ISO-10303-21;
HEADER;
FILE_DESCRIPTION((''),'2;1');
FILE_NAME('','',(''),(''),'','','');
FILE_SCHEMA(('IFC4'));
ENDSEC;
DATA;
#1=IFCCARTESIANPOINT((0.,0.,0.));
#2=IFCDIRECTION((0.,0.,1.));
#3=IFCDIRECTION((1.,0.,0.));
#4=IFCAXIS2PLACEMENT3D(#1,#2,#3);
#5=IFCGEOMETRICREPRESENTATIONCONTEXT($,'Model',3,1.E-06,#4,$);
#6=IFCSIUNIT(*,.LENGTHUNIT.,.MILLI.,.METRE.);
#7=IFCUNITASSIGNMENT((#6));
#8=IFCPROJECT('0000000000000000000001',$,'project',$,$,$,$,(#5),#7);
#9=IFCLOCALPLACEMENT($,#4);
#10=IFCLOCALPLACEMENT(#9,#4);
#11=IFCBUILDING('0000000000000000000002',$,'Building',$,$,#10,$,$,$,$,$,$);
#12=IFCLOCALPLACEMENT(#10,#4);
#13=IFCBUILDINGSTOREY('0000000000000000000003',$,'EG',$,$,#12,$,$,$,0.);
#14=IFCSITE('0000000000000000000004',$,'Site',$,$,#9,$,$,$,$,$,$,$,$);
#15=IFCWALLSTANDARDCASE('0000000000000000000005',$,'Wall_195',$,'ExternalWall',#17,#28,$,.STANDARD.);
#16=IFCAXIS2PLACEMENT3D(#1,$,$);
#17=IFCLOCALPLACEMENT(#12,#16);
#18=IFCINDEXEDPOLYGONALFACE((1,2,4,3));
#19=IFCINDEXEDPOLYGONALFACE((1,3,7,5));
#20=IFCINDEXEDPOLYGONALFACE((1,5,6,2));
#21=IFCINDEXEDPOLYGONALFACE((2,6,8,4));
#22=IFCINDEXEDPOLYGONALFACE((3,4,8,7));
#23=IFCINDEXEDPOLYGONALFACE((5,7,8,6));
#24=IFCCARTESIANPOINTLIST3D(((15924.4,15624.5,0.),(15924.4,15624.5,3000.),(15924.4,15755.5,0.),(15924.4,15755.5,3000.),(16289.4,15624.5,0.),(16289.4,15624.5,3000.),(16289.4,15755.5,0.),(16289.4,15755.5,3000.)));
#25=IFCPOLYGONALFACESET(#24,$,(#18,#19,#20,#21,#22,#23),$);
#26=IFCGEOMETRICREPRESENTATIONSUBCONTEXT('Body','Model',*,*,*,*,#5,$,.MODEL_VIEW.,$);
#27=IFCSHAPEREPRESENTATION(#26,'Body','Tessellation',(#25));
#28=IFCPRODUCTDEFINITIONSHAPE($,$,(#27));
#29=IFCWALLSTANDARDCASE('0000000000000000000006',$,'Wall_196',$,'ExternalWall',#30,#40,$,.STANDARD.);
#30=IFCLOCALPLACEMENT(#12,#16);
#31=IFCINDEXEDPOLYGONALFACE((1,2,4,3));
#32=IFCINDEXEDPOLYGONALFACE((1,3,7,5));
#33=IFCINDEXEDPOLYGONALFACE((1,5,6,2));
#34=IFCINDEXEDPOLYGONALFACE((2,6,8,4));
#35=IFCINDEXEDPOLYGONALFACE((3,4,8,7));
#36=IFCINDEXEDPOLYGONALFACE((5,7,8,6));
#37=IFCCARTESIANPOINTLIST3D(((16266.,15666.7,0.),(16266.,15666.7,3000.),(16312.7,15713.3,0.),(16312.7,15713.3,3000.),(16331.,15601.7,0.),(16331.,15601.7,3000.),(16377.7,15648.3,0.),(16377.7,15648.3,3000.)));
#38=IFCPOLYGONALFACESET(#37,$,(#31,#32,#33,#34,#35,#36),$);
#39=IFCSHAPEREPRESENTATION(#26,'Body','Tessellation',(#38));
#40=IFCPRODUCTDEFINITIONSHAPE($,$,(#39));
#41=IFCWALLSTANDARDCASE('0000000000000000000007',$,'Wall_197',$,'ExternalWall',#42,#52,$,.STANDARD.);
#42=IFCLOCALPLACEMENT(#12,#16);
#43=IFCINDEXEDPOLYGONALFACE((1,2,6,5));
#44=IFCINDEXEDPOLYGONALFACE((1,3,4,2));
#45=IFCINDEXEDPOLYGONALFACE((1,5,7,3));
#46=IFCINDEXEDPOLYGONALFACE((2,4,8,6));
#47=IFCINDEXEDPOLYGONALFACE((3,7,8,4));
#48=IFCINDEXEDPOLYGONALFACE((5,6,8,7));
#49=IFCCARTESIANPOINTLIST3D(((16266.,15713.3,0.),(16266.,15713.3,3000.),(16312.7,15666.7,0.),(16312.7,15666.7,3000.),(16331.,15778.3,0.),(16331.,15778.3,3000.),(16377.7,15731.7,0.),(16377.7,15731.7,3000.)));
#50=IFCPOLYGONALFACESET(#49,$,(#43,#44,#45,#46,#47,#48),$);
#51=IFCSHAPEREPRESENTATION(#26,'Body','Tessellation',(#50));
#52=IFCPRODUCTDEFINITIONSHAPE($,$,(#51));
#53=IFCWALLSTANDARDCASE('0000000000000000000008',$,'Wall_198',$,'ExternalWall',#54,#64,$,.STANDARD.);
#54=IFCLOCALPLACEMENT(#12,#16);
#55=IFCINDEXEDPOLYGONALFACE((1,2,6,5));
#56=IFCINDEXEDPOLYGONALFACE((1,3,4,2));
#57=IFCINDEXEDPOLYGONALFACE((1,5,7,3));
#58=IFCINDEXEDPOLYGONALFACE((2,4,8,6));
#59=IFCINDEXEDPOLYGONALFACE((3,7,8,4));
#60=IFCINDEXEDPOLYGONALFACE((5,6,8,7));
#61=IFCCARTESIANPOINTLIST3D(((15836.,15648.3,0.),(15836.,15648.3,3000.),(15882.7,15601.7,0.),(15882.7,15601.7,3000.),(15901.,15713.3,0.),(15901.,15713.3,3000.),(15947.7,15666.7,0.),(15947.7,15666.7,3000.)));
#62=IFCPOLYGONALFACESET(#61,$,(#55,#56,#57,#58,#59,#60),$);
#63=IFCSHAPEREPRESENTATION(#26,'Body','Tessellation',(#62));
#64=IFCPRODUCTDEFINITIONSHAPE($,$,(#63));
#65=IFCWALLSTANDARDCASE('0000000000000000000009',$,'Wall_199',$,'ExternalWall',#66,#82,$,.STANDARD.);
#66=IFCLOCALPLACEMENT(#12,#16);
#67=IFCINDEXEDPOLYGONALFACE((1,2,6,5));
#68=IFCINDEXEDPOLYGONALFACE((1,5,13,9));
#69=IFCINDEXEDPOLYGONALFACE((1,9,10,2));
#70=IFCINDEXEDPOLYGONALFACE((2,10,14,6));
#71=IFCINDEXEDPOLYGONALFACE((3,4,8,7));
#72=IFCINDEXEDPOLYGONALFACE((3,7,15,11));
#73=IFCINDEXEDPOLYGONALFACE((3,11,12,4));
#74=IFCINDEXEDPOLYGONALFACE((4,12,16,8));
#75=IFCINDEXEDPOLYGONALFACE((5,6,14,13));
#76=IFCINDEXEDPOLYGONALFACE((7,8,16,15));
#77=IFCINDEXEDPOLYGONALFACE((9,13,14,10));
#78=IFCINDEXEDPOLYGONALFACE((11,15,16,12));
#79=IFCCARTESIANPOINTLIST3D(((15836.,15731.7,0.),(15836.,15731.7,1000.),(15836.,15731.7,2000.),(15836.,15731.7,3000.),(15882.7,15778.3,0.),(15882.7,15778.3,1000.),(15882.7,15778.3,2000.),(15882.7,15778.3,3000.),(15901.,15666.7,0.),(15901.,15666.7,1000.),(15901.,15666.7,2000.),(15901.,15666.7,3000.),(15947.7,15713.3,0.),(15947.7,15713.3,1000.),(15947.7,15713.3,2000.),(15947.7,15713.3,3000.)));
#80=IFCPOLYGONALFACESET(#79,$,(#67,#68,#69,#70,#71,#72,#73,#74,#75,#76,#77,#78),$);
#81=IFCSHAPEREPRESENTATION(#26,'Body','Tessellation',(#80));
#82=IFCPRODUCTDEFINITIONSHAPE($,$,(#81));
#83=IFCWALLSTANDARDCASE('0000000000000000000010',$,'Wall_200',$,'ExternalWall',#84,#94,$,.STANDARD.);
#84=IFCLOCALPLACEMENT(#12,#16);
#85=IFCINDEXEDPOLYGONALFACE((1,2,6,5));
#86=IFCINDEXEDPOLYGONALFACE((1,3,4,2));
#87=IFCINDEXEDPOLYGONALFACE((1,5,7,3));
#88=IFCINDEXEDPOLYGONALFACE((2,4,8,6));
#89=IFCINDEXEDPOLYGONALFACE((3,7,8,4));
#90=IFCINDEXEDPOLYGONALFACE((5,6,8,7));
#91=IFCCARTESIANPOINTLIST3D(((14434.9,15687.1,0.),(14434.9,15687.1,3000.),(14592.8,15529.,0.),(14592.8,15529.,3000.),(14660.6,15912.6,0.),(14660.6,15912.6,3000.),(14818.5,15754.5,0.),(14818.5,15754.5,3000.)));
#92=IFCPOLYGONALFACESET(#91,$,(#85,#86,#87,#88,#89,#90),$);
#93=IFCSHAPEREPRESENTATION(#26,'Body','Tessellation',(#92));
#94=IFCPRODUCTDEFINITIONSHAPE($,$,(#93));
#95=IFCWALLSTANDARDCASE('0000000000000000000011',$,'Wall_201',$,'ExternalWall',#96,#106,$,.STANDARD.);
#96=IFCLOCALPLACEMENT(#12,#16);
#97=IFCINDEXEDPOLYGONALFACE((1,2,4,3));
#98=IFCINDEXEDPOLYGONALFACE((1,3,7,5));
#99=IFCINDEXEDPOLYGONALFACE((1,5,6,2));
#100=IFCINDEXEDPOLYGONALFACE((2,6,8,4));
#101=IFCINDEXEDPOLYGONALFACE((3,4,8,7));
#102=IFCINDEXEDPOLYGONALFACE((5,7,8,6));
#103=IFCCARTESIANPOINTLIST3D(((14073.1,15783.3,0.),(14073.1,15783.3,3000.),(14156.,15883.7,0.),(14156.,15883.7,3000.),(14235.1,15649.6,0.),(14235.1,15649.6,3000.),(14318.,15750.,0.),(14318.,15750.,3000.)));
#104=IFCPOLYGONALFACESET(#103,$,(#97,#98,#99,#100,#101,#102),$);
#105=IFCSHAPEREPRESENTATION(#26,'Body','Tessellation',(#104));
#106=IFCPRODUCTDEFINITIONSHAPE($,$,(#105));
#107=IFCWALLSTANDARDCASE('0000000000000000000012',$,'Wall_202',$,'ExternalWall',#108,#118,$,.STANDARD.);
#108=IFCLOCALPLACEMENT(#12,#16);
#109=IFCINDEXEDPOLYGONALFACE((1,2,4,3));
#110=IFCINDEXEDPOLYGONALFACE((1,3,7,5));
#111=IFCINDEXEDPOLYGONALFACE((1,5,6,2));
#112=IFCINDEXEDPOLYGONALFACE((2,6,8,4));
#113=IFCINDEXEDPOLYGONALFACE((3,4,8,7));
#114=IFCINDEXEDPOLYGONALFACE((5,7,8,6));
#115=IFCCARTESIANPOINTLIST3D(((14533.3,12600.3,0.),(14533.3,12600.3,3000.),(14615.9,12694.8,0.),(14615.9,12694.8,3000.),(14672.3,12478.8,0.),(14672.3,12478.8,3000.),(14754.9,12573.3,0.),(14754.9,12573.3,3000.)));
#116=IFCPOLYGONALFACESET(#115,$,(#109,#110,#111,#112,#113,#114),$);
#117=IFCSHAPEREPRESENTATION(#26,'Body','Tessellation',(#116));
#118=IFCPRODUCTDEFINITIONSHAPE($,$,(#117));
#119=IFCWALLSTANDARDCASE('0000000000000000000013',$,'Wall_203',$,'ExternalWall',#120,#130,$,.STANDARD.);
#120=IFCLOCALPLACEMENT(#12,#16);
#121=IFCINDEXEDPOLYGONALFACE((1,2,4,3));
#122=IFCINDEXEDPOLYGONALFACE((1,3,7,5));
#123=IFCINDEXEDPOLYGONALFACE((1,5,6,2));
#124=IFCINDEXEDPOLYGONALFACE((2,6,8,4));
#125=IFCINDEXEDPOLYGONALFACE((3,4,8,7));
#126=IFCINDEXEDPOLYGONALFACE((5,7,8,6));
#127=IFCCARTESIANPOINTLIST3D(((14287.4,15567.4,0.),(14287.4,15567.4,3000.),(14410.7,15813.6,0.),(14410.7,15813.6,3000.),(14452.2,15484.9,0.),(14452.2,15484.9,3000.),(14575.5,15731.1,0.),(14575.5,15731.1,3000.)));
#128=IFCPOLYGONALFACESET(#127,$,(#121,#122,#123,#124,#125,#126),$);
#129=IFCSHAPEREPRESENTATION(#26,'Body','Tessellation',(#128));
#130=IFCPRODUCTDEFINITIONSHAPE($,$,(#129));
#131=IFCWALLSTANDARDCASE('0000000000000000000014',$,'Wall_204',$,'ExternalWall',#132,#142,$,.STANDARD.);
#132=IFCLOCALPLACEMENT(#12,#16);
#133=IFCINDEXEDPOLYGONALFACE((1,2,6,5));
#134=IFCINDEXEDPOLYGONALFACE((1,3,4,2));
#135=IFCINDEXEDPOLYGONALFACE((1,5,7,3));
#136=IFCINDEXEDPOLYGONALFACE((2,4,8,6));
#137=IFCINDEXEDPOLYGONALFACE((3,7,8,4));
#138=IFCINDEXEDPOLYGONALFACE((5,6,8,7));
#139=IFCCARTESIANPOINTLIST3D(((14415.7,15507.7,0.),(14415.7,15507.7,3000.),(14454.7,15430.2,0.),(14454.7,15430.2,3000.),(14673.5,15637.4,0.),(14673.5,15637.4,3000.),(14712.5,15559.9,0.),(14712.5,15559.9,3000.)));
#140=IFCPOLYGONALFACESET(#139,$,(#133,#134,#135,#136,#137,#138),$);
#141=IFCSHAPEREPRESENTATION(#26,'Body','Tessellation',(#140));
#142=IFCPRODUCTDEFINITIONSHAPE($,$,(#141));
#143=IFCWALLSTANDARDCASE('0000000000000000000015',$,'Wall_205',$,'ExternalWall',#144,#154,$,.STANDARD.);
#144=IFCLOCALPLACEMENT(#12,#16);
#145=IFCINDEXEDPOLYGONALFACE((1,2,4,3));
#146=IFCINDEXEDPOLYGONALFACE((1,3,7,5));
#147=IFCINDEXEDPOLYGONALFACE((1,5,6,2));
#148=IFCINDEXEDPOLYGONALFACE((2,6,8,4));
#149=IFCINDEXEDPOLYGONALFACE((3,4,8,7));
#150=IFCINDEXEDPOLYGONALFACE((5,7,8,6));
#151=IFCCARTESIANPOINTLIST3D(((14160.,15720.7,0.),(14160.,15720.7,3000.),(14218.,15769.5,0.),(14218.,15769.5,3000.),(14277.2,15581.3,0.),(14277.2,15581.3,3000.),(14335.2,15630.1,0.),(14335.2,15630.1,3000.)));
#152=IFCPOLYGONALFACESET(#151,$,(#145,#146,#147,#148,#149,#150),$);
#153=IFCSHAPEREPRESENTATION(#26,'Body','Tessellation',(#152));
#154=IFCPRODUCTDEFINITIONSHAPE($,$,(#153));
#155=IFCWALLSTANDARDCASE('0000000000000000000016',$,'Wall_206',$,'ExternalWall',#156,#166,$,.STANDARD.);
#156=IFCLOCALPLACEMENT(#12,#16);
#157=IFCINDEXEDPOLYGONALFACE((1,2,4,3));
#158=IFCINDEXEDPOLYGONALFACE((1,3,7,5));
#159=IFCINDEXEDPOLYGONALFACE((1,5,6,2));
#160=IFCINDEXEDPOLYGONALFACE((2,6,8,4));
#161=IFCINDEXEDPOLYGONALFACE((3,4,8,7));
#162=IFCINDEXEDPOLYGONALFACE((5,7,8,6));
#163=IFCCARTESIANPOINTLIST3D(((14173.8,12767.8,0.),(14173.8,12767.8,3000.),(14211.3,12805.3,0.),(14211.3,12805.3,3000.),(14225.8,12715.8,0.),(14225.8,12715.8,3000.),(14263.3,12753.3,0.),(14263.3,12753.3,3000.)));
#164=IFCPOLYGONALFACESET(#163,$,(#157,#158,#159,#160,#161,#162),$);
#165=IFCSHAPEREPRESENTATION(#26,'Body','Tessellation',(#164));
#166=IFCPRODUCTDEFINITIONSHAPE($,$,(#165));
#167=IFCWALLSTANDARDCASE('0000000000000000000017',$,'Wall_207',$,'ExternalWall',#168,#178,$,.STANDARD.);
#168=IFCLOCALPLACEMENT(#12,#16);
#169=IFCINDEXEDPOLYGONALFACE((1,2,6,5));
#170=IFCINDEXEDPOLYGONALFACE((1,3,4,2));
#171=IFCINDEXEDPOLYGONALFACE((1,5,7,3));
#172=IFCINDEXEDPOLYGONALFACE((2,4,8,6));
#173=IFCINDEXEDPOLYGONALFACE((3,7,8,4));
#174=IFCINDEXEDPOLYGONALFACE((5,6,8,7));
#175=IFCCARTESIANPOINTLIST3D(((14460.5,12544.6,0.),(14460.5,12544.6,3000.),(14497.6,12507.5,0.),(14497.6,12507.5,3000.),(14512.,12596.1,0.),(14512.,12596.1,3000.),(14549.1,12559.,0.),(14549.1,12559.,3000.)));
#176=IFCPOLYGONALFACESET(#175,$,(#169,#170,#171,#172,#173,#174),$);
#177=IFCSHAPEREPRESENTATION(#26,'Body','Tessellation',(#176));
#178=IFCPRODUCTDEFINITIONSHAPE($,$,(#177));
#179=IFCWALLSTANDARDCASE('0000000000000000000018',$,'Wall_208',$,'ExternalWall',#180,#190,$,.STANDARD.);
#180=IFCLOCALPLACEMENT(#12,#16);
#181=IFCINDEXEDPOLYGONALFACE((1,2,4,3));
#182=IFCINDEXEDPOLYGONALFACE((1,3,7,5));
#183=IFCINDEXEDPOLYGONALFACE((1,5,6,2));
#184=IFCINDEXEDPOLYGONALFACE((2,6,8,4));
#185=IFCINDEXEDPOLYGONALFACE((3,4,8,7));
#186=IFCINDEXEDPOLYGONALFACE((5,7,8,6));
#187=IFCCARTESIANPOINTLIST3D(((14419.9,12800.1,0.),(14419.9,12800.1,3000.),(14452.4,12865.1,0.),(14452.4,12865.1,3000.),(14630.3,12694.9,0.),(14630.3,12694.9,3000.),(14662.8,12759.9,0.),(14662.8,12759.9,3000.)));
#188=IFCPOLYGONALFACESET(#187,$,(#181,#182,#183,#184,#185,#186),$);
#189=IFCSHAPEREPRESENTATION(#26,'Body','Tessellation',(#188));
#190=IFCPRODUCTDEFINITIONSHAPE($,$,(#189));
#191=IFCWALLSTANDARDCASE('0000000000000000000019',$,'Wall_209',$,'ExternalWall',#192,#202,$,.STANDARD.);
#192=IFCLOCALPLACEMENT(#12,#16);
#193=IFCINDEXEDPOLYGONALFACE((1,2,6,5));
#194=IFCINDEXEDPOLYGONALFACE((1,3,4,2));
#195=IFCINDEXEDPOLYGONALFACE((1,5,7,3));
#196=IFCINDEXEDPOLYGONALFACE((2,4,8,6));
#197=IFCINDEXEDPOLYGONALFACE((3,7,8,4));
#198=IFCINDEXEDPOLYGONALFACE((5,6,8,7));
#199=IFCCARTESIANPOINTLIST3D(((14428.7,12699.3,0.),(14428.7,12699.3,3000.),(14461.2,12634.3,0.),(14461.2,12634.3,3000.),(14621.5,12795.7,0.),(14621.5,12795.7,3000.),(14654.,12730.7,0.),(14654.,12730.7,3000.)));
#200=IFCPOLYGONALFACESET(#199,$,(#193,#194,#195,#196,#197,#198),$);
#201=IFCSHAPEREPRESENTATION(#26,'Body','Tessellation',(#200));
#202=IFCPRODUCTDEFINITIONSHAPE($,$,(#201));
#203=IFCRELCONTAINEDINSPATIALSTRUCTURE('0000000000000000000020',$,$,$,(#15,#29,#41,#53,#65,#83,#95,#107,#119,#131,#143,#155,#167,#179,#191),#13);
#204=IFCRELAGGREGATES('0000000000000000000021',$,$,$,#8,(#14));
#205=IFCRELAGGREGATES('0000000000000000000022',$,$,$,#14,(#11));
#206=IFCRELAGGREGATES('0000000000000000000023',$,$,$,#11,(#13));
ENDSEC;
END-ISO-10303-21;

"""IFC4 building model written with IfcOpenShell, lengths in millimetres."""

from ifc_helpers import new_model, si_unit, frame, origin_with_axes, place, context, subcontext, project, spatial, rectangle, extrude, element, save


model = new_model("IFC4")

# Units and contexts
model_context = context("Model", 3, precision=1e-06, world=origin_with_axes())
body_context = subcontext(model_context, "Body", "Model", "MODEL_VIEW")
ifc_project = project(units=[si_unit("LENGTHUNIT", "METRE", prefix="MILLI")], contexts=[model_context])

# Site, building, storey
site_placement = place(None, origin_with_axes())
site = spatial("IfcSite", under=ifc_project, at=site_placement, Name="Site")
building_placement = place(site_placement, origin_with_axes())
building = spatial("IfcBuilding", under=site, at=building_placement, Name="Building")
storey_placement = place(building_placement, origin_with_axes())
storey = spatial("IfcBuildingStorey", under=building, at=storey_placement, Name="EG", Elevation=0.0)

# Walls
wall_1_placement = place(storey_placement, origin_with_axes())
element("IfcWallStandardCase", 1, at=wall_1_placement, inside=storey, Name="Wall_195", ObjectType="ExternalWall", PredefinedType="STANDARD", context=body_context, shape_type="SweptSolid", body=[
    extrude(rectangle(XDim=365.0, YDim=131.0), frame((16106.9, 15690.0, 0.0), z_axis=(0.0, 0.0, 1.0), x_axis=(-1.0, 0.0, 0.0)), (0.0, 0.0, 1.0), 3000.0),
])
wall_2_placement = place(storey_placement, origin_with_axes())
element("IfcWallStandardCase", 2, at=wall_2_placement, inside=storey, Name="Wall_196", ObjectType="ExternalWall", PredefinedType="STANDARD", context=body_context, shape_type="SweptSolid", body=[
    extrude(rectangle(XDim=91.9, YDim=66.0), frame((16321.9, 15657.5, 0.0), z_axis=(0.0, 0.0, 1.0), x_axis=(0.707107, -0.707107, 0.0)), (0.0, 0.0, 1.0), 3000.0),
])
wall_3_placement = place(storey_placement, origin_with_axes())
element("IfcWallStandardCase", 3, at=wall_3_placement, inside=storey, Name="Wall_197", ObjectType="ExternalWall", PredefinedType="STANDARD", context=body_context, shape_type="SweptSolid", body=[
    extrude(rectangle(XDim=91.9, YDim=66.0), frame((16321.9, 15722.5, 0.0), z_axis=(0.0, 0.0, 1.0), x_axis=(0.707107, 0.707107, 0.0)), (0.0, 0.0, 1.0), 3000.0),
])
wall_4_placement = place(storey_placement, origin_with_axes())
element("IfcWallStandardCase", 4, at=wall_4_placement, inside=storey, Name="Wall_198", ObjectType="ExternalWall", PredefinedType="STANDARD", context=body_context, shape_type="SweptSolid", body=[
    extrude(rectangle(XDim=91.9, YDim=66.0), frame((15891.9, 15657.5, 0.0), z_axis=(0.0, 0.0, 1.0), x_axis=(-0.707107, -0.707107, 0.0)), (0.0, 0.0, 1.0), 3000.0),
])

# Wall, opening
wall_5_placement = place(storey_placement, origin_with_axes())
wall_5 = element("IfcWallStandardCase", 5, at=wall_5_placement, inside=storey, Name="Wall_199", ObjectType="ExternalWall", PredefinedType="STANDARD", context=body_context, shape_type="SweptSolid", body=[
    extrude(rectangle(XDim=91.9, YDim=66.0), frame((15891.9, 15722.5, 0.0), z_axis=(0.0, 0.0, 1.0), x_axis=(-0.707107, 0.707107, 0.0)), (0.0, 0.0, 1.0), 3000.0),
])
opening_placement = place(wall_5_placement, origin_with_axes())
element("IfcOpeningElement", 6, at=opening_placement, inside=storey, cuts=wall_5, context=body_context, shape_type="SweptSolid", body=[
    extrude(rectangle(XDim=600.0, YDim=66.0), frame((15878.9, 15735.5, 1000.0), z_axis=(0.0, 0.0, 1.0), x_axis=(-0.707107, 0.707107, 0.0)), (0.0, 0.0, 1.0), 1000.0),
])

# Walls
wall_6_placement = place(storey_placement, origin_with_axes())
element("IfcWallStandardCase", 7, at=wall_6_placement, inside=storey, Name="Wall_200", ObjectType="ExternalWall", PredefinedType="STANDARD", context=body_context, shape_type="SweptSolid", body=[
    extrude(rectangle(XDim=319.1, YDim=223.5), frame((14626.7, 15720.8, 0.0), z_axis=(0.0, 0.0, 1.0), x_axis=(0.707498, 0.706715, 0.0)), (0.0, 0.0, 1.0), 3000.0),
])
wall_7_placement = place(storey_placement, origin_with_axes())
element("IfcWallStandardCase", 8, at=wall_7_placement, inside=storey, Name="Wall_201", ObjectType="ExternalWall", PredefinedType="STANDARD", context=body_context, shape_type="SweptSolid", body=[
    extrude(rectangle(XDim=210.1, YDim=130.2), frame((14195.6, 15766.7, 0.0), z_axis=(0.0, 0.0, 1.0), x_axis=(-0.77114, 0.636666, 0.0)), (0.0, 0.0, 1.0), 3000.0),
])
wall_8_placement = place(storey_placement, origin_with_axes())
element("IfcWallStandardCase", 9, at=wall_8_placement, inside=storey, Name="Wall_202", ObjectType="ExternalWall", PredefinedType="STANDARD", context=body_context, shape_type="SweptSolid", body=[
    extrude(rectangle(XDim=184.6, YDim=125.5), frame((14644.1, 12586.8, 0.0), z_axis=(0.0, 0.0, 1.0), x_axis=(0.752912, -0.658121, 0.0)), (0.0, 0.0, 1.0), 3000.0),
])
wall_9_placement = place(storey_placement, origin_with_axes())
element("IfcWallStandardCase", 10, at=wall_9_placement, inside=storey, Name="Wall_203", ObjectType="ExternalWall", PredefinedType="STANDARD", context=body_context, shape_type="SweptSolid", body=[
    extrude(rectangle(XDim=184.3, YDim=275.3), frame((14431.5, 15649.3, 0.0), z_axis=(0.0, 0.0, 1.0), x_axis=(-0.894156, 0.447756, 0.0)), (0.0, 0.0, 1.0), 3000.0),
])
wall_10_placement = place(storey_placement, origin_with_axes())
element("IfcWallStandardCase", 11, at=wall_10_placement, inside=storey, Name="Wall_204", ObjectType="ExternalWall", PredefinedType="STANDARD", context=body_context, shape_type="SweptSolid", body=[
    extrude(rectangle(XDim=86.8, YDim=288.6), frame((14564.1, 15533.8, 0.0), z_axis=(0.0, 0.0, 1.0), x_axis=(-0.449517, 0.893272, 0.0)), (0.0, 0.0, 1.0), 3000.0),
])
wall_11_placement = place(storey_placement, origin_with_axes())
element("IfcWallStandardCase", 12, at=wall_11_placement, inside=storey, Name="Wall_205", ObjectType="ExternalWall", PredefinedType="STANDARD", context=body_context, shape_type="SweptSolid", body=[
    extrude(rectangle(XDim=75.8, YDim=182.1), frame((14247.6, 15675.4, 0.0), z_axis=(0.0, 0.0, 1.0), x_axis=(-0.76551, -0.643424, 0.0)), (0.0, 0.0, 1.0), 3000.0),
])
wall_12_placement = place(storey_placement, origin_with_axes())
element("IfcWallStandardCase", 13, at=wall_12_placement, inside=storey, Name="Wall_206", ObjectType="ExternalWall", PredefinedType="STANDARD", context=body_context, shape_type="SweptSolid", body=[
    extrude(rectangle(XDim=73.5, YDim=53.0), frame((14218.6, 12760.5, 0.0), z_axis=(0.0, 0.0, 1.0), x_axis=(0.707107, -0.707107, 0.0)), (0.0, 0.0, 1.0), 3000.0),
])
wall_13_placement = place(storey_placement, origin_with_axes())
element("IfcWallStandardCase", 14, at=wall_13_placement, inside=storey, Name="Wall_207", ObjectType="ExternalWall", PredefinedType="STANDARD", context=body_context, shape_type="SweptSolid", body=[
    extrude(rectangle(XDim=72.8, YDim=52.5), frame((14504.8, 12551.8, 0.0), z_axis=(0.0, 0.0, 1.0), x_axis=(-0.707107, -0.707107, 0.0)), (0.0, 0.0, 1.0), 3000.0),
])
wall_14_placement = place(storey_placement, origin_with_axes())
element("IfcWallStandardCase", 15, at=wall_14_placement, inside=storey, Name="Wall_208", ObjectType="ExternalWall", PredefinedType="STANDARD", context=body_context, shape_type="SweptSolid", body=[
    extrude(rectangle(XDim=72.7, YDim=235.2), frame((14541.3, 12780.0, 0.0), z_axis=(0.0, 0.0, 1.0), x_axis=(-0.447214, -0.894427, 0.0)), (0.0, 0.0, 1.0), 3000.0),
])
wall_15_placement = place(storey_placement, origin_with_axes())
element("IfcWallStandardCase", 16, at=wall_15_placement, inside=storey, Name="Wall_209", ObjectType="ExternalWall", PredefinedType="STANDARD", context=body_context, shape_type="SweptSolid", body=[
    extrude(rectangle(XDim=72.7, YDim=215.6), frame((14541.3, 12715.0, 0.0), z_axis=(0.0, 0.0, 1.0), x_axis=(0.447214, -0.894427, 0.0)), (0.0, 0.0, 1.0), 3000.0),
])

save(model, "model.ifc")
